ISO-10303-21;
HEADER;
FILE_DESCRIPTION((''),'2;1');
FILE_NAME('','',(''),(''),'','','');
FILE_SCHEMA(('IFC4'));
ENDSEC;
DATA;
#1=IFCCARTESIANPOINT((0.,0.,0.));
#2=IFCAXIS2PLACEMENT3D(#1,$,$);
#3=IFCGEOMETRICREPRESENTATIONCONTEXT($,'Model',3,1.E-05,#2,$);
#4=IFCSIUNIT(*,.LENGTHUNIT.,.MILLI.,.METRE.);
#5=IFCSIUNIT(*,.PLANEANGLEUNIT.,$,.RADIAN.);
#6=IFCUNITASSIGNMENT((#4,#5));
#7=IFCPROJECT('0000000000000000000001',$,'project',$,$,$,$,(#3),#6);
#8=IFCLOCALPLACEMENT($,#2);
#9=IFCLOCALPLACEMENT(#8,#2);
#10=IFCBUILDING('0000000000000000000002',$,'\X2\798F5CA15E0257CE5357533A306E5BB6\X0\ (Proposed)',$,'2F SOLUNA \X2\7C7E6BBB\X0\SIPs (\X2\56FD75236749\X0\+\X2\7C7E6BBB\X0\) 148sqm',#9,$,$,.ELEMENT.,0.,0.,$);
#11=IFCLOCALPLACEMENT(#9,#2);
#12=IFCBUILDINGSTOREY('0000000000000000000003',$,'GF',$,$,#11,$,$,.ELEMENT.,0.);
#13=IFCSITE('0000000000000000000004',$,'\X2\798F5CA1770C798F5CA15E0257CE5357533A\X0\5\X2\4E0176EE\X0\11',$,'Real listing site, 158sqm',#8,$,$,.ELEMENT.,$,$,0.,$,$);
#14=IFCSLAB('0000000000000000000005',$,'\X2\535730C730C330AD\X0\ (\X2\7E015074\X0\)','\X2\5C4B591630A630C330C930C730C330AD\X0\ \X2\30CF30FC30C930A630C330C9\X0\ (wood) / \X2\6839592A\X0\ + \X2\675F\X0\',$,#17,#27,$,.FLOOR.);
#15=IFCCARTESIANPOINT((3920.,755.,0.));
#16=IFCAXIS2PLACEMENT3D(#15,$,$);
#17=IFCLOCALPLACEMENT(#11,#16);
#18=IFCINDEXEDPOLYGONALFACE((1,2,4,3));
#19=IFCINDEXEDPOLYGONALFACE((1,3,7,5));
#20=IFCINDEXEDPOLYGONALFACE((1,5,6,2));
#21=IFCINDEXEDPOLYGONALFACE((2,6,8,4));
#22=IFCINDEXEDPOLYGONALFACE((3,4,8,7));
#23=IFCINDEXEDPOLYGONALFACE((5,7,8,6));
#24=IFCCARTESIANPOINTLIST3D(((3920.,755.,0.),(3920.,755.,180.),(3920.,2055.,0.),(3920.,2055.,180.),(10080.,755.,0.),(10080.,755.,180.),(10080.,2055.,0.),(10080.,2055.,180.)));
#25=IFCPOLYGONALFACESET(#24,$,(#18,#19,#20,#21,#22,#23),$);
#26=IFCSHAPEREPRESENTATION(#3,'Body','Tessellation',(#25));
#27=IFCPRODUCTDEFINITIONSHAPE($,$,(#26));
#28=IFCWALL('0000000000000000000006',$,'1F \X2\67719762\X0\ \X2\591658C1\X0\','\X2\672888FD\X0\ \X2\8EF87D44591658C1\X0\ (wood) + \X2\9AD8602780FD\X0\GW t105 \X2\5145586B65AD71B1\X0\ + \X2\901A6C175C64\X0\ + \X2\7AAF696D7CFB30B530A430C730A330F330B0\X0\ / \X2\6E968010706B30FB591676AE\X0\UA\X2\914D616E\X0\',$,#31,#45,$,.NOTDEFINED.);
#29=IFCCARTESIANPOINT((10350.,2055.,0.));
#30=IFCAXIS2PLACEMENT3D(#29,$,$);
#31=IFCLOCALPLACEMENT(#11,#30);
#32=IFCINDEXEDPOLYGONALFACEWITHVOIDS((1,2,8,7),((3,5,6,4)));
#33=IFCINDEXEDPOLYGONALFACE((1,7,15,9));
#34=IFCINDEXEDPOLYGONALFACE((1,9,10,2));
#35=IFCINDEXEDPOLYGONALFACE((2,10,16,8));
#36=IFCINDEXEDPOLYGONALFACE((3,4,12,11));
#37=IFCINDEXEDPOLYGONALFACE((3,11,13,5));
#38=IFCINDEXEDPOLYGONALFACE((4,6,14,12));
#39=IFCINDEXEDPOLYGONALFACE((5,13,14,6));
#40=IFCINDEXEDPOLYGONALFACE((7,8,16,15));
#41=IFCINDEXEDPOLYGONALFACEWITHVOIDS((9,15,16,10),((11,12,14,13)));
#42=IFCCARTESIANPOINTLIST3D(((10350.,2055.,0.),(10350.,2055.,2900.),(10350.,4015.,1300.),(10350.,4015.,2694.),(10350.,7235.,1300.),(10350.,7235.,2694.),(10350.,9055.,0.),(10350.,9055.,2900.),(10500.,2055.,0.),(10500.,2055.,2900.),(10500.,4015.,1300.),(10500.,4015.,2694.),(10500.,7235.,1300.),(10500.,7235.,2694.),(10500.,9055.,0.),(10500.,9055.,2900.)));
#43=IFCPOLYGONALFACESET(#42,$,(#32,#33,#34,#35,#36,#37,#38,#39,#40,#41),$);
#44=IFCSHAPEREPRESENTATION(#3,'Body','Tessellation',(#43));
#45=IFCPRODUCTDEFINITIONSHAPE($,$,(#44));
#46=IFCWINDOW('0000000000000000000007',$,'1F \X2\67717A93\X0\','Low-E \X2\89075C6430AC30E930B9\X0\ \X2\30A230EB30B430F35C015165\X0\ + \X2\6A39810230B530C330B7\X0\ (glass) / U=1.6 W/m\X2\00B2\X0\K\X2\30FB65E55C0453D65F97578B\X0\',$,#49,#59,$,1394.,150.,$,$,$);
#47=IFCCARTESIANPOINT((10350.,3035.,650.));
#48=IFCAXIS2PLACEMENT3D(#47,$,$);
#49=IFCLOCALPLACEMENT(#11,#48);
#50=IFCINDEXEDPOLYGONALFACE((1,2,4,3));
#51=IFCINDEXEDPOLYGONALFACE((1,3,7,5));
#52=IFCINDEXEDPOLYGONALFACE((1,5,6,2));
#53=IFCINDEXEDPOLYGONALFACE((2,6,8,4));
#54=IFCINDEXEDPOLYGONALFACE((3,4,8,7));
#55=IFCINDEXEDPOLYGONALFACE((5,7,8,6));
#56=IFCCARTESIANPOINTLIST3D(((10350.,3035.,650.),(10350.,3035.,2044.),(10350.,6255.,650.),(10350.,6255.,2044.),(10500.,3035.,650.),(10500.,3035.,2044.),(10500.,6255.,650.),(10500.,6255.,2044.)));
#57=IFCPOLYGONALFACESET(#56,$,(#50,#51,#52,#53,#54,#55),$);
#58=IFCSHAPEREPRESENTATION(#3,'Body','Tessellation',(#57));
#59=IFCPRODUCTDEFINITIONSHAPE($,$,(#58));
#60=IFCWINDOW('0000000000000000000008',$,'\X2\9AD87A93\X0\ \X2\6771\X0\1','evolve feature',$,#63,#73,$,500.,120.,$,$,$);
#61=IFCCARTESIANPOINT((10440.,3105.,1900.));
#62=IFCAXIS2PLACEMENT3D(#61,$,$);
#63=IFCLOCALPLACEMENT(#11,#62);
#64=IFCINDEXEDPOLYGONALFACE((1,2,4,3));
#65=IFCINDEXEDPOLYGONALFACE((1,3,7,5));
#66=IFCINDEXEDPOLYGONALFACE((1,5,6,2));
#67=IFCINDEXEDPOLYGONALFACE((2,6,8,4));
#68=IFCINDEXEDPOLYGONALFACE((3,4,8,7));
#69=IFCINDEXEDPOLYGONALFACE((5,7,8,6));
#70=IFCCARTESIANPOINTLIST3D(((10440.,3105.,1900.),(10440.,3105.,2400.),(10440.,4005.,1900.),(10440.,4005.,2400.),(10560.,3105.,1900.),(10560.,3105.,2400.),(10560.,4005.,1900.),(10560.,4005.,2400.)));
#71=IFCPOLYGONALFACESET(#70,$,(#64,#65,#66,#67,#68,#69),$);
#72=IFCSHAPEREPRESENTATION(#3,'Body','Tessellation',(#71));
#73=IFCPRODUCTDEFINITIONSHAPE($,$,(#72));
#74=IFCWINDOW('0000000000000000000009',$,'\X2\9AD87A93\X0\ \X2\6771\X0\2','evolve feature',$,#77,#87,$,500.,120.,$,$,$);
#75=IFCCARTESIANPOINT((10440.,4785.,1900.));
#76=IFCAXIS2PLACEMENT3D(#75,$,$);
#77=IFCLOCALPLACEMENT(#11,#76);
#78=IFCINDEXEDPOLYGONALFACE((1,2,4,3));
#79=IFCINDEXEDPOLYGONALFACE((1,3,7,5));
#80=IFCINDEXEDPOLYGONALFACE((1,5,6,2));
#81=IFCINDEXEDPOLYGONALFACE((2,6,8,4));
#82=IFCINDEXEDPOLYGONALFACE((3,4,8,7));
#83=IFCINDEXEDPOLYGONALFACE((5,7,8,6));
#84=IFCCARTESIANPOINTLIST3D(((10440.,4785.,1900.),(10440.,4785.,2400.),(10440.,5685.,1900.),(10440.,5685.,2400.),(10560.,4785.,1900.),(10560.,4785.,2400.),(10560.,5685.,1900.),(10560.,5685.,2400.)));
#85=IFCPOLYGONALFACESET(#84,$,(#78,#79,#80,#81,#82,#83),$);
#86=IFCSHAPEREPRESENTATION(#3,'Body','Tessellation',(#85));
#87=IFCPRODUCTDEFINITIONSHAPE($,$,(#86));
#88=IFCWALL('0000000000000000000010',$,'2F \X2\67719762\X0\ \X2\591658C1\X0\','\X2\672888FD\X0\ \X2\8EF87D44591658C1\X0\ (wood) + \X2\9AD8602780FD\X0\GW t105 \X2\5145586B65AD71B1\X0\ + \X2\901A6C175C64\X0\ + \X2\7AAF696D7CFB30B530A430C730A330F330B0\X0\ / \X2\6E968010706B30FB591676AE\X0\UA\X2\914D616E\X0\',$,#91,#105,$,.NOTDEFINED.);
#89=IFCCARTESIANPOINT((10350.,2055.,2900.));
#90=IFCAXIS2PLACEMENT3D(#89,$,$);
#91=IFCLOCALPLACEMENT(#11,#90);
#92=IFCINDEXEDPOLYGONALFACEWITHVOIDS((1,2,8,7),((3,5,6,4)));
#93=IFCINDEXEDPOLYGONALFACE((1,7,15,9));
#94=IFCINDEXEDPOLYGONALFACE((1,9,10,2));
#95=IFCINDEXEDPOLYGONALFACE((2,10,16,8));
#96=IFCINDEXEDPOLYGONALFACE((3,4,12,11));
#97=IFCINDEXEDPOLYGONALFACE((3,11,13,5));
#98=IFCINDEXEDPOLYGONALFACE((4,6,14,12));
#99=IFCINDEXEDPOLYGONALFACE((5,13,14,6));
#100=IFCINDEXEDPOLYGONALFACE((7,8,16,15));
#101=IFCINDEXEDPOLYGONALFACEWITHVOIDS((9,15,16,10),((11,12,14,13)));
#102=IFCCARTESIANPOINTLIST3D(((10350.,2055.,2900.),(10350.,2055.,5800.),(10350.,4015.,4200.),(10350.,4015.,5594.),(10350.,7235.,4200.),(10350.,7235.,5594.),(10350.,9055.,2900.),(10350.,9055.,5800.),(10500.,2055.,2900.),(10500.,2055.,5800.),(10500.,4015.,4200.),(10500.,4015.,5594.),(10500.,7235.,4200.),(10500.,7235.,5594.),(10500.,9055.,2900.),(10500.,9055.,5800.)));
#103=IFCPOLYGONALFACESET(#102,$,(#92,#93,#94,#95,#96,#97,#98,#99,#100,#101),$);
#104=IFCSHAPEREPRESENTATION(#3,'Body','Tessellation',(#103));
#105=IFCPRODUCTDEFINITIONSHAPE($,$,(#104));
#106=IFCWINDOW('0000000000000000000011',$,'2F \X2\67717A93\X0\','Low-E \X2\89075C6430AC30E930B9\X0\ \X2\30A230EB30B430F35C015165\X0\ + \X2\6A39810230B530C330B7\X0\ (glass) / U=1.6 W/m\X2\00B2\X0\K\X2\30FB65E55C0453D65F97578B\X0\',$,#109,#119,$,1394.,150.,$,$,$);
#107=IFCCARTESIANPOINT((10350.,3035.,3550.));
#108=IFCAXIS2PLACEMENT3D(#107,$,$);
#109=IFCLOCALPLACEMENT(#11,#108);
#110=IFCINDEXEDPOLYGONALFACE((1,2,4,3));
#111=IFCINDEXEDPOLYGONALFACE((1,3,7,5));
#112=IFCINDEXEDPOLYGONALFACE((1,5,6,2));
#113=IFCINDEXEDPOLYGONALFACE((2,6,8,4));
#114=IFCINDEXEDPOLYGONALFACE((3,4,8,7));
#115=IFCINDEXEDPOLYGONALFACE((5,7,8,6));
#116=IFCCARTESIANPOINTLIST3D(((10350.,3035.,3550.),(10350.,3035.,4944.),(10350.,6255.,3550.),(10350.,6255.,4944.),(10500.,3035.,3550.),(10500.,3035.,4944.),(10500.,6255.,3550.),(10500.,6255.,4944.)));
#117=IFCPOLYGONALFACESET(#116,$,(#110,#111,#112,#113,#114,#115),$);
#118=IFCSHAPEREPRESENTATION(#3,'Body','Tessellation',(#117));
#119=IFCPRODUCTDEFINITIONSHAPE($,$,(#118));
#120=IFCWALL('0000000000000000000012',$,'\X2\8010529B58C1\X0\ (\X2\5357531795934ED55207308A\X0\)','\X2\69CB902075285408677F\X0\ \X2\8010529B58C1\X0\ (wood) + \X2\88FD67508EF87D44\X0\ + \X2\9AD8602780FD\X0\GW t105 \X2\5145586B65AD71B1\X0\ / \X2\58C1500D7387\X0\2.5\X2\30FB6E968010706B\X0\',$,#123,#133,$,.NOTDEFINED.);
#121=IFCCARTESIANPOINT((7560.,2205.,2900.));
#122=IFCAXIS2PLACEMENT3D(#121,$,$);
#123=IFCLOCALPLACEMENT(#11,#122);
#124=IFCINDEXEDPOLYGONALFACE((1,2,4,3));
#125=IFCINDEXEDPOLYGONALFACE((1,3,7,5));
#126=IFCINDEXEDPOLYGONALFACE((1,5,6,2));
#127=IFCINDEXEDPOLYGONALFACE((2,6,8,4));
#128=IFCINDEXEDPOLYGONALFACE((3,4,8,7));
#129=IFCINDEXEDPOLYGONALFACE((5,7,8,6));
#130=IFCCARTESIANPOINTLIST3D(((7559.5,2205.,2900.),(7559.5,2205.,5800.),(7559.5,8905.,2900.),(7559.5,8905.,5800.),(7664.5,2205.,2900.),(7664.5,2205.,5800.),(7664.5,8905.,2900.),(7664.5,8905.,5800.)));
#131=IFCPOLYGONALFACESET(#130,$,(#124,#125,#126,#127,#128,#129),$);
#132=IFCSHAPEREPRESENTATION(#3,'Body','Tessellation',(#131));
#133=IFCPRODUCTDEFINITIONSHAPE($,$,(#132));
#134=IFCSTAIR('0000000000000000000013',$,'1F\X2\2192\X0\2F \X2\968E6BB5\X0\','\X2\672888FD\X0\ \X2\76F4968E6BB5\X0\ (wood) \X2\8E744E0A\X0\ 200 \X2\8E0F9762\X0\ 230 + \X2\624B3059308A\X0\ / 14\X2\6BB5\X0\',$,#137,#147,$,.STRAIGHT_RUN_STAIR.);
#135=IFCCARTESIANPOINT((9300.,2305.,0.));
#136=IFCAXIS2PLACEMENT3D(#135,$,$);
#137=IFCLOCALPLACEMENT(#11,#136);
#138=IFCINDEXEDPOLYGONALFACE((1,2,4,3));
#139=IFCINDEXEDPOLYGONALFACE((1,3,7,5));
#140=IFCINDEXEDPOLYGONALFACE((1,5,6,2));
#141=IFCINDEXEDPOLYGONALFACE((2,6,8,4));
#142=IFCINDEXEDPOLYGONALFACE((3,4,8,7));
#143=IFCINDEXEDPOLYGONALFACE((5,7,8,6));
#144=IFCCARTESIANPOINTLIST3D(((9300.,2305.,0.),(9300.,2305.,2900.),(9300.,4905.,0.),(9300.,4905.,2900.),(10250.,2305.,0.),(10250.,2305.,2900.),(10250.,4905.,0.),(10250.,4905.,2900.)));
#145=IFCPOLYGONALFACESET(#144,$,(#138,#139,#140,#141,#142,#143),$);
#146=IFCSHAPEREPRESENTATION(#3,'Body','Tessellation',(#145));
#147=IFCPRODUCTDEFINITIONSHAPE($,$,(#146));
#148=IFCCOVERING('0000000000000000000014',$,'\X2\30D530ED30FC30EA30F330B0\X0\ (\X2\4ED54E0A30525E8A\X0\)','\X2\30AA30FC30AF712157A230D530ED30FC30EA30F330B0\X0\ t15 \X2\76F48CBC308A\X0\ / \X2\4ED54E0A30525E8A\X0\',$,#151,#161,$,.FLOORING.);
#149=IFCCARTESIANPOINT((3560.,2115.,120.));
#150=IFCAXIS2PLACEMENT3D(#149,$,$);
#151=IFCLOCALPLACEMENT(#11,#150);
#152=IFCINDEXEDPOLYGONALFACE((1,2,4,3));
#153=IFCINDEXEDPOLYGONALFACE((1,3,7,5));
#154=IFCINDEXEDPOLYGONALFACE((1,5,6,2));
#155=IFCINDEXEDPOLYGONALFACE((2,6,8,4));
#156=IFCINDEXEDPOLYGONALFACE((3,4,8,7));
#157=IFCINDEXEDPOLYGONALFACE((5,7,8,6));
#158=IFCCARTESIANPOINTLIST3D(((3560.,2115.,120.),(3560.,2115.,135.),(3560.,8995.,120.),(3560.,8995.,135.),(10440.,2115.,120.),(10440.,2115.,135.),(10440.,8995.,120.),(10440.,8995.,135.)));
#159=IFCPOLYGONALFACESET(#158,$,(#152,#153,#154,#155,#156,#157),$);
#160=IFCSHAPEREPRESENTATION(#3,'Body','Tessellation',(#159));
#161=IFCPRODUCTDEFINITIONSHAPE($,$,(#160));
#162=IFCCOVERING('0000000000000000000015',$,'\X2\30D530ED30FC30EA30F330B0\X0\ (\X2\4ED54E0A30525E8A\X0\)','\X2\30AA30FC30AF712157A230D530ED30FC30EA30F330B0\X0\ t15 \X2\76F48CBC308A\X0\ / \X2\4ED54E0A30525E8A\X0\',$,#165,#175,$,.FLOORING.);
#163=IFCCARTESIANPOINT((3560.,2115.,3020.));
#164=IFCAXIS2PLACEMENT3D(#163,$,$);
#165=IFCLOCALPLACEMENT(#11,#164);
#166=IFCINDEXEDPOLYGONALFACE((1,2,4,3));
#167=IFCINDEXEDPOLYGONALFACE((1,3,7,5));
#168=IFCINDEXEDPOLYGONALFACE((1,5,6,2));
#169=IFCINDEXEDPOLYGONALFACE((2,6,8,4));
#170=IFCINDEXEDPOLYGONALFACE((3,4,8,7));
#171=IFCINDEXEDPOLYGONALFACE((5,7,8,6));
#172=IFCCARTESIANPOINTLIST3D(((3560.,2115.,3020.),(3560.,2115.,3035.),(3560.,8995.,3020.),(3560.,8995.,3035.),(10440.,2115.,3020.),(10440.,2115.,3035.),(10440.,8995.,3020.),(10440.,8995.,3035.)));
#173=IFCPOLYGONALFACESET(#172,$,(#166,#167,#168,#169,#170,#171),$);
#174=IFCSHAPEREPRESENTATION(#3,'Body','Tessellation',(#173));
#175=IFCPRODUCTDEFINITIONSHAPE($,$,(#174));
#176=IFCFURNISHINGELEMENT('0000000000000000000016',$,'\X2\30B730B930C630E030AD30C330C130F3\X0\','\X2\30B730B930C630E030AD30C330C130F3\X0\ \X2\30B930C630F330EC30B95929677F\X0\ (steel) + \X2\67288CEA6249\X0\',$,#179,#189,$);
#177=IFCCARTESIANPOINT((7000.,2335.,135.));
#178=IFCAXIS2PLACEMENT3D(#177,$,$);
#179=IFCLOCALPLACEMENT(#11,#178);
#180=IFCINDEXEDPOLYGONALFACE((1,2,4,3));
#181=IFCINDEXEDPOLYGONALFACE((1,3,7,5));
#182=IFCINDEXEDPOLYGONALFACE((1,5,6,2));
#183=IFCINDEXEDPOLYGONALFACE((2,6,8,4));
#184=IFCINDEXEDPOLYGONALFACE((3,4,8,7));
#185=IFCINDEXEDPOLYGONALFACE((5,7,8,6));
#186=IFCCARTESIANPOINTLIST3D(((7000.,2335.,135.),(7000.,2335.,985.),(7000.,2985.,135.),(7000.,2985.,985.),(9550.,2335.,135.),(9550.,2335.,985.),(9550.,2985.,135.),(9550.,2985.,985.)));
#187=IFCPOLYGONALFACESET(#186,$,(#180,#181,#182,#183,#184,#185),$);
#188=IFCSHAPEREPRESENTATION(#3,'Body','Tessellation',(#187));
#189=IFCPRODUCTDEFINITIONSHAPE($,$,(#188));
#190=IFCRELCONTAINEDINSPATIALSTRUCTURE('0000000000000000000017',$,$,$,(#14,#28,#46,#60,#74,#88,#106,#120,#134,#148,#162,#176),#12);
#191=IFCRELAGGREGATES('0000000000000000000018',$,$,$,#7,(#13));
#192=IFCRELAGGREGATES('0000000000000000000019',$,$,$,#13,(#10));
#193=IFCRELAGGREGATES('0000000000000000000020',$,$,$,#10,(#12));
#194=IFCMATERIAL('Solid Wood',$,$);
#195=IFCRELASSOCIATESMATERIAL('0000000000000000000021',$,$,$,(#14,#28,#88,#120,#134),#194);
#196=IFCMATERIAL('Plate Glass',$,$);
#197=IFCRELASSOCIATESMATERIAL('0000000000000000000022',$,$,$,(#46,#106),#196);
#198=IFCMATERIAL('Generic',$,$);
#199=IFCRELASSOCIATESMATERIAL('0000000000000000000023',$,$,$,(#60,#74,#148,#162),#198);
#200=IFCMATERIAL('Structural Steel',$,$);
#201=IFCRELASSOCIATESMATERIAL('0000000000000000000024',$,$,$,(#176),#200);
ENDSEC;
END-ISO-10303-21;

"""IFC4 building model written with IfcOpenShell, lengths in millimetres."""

from ifc_helpers import new_model, si_unit, frame, frame_2d, origin, place, context, project, spatial, rectangle, extrude, material, element, fill, save


model = new_model("IFC4")

# Units and contexts
model_context = context("Model", 3, precision=1e-05, world=origin())
ifc_project = project(units=[si_unit("LENGTHUNIT", "METRE", prefix="MILLI"), si_unit("PLANEANGLEUNIT", "RADIAN")], contexts=[model_context])

# Site, building, storey
site_placement = place(None, origin())
site = spatial("IfcSite", under=ifc_project, at=site_placement, Name="福岡県福岡市城南区5丁目11", ObjectType="Real listing site, 158sqm", CompositionType="ELEMENT", RefElevation=0.0)
building_placement = place(site_placement, origin())
building = spatial("IfcBuilding", under=site, at=building_placement, Name="福岡市城南区の家 (Proposed)", ObjectType="2F SOLUNA 籾殻SIPs (国産杉+籾殻) 148sqm", CompositionType="ELEMENT", ElevationOfRefHeight=0.0, ElevationOfTerrain=0.0)
storey_placement = place(building_placement, origin())
storey = spatial("IfcBuildingStorey", under=building, at=storey_placement, Name="GF", CompositionType="ELEMENT", Elevation=0.0)

# Slab
ifc_material_1 = material(Name="Solid Wood")
slab_placement = place(storey_placement, frame((3920.0, 755.0, 0.0)))
element("IfcSlab", 1, at=slab_placement, inside=storey, material=ifc_material_1, Name="南デッキ (縁側)", Description="屋外ウッドデッキ ハードウッド (wood) / 根太 + 束", PredefinedType="FLOOR", context=model_context, shape_type="SweptSolid", body=[
    extrude(rectangle(XDim=6160.0, YDim=1300.0, at=frame_2d((3080.0, 650.0))), frame((3920.0, 755.0, 0.0)), (0.0, 0.0, 1.0), 180.0),
])

# Wall, openings, windows
wall_1_placement = place(storey_placement, frame((10350.0, 2055.0, 0.0)))
wall_1 = element("IfcWall", 2, at=wall_1_placement, inside=storey, material=ifc_material_1, Name="1F 東面 外壁", Description="木製 軸組外壁 (wood) + 高性能GW t105 充填断熱 + 通気層 + 窯業系サイディング / 準耐火・外皮UA配慮", PredefinedType="NOTDEFINED", context=model_context, shape_type="SweptSolid", body=[
    extrude(rectangle(XDim=150.0, YDim=7000.0, at=frame_2d((75.0, 3500.0))), frame((10350.0, 2055.0, 0.0)), (0.0, 0.0, 1.0), 2900.0),
])
opening_1_placement = place(storey_placement, frame((10350.0, 3035.0, 650.0)))
opening_1 = element("IfcOpeningElement", 3, at=opening_1_placement, cuts=wall_1, PredefinedType="NOTDEFINED", context=model_context, shape_type="SweptSolid", body=[
    extrude(rectangle(XDim=150.0, YDim=3220.0, at=frame_2d((75.0, 1610.0))), frame((10350.0, 3035.0, 650.0)), (0.0, 0.0, 1.0), 1394.0),
])
opening_2_placement = place(storey_placement, frame((10440.0, 3105.0, 1900.0)))
opening_2 = element("IfcOpeningElement", 4, at=opening_2_placement, cuts=wall_1, PredefinedType="NOTDEFINED", context=model_context, shape_type="SweptSolid", body=[
    extrude(rectangle(XDim=120.0, YDim=900.0, at=frame_2d((60.0, 450.0))), frame((10440.0, 3105.0, 1900.0)), (0.0, 0.0, 1.0), 500.0),
])
opening_3_placement = place(storey_placement, frame((10440.0, 4785.0, 1900.0)))
opening_3 = element("IfcOpeningElement", 5, at=opening_3_placement, cuts=wall_1, PredefinedType="NOTDEFINED", context=model_context, shape_type="SweptSolid", body=[
    extrude(rectangle(XDim=120.0, YDim=900.0, at=frame_2d((60.0, 450.0))), frame((10440.0, 4785.0, 1900.0)), (0.0, 0.0, 1.0), 500.0),
])
ifc_material_2 = material(Name="Plate Glass")
window_1_placement = place(storey_placement, frame((10350.0, 3035.0, 650.0)))
window_1 = element("IfcWindow", 6, at=window_1_placement, inside=storey, material=ifc_material_2, Name="1F 東窓", Description="Low-E 複層ガラス アルゴン封入 + 樹脂サッシ (glass) / U=1.6 W/m²K・日射取得型", OverallHeight=1394.0, OverallWidth=150.0, context=model_context, shape_type="SweptSolid", body=[
    extrude(rectangle(XDim=150.0, YDim=3220.0, at=frame_2d((75.0, 1610.0))), frame((10350.0, 3035.0, 650.0)), (0.0, 0.0, 1.0), 1394.0),
])
fill(opening_1, window_1)
ifc_material_3 = material(Name="Generic")
window_2_placement = place(storey_placement, frame((10440.0, 3105.0, 1900.0)))
window_2 = element("IfcWindow", 7, at=window_2_placement, inside=storey, material=ifc_material_3, Name="高窓 東1", Description="evolve feature", OverallHeight=500.0, OverallWidth=120.0, context=model_context, shape_type="SweptSolid", body=[
    extrude(rectangle(XDim=120.0, YDim=900.0, at=frame_2d((60.0, 450.0))), frame((10440.0, 3105.0, 1900.0)), (0.0, 0.0, 1.0), 500.0),
])
fill(opening_2, window_2)
window_3_placement = place(storey_placement, frame((10440.0, 4785.0, 1900.0)))
window_3 = element("IfcWindow", 8, at=window_3_placement, inside=storey, material=ifc_material_3, Name="高窓 東2", Description="evolve feature", OverallHeight=500.0, OverallWidth=120.0, context=model_context, shape_type="SweptSolid", body=[
    extrude(rectangle(XDim=120.0, YDim=900.0, at=frame_2d((60.0, 450.0))), frame((10440.0, 4785.0, 1900.0)), (0.0, 0.0, 1.0), 500.0),
])
fill(opening_3, window_3)

# Wall, opening, window
wall_2_placement = place(storey_placement, frame((10350.0, 2055.0, 2900.0)))
wall_2 = element("IfcWall", 9, at=wall_2_placement, inside=storey, material=ifc_material_1, Name="2F 東面 外壁", Description="木製 軸組外壁 (wood) + 高性能GW t105 充填断熱 + 通気層 + 窯業系サイディング / 準耐火・外皮UA配慮", PredefinedType="NOTDEFINED", context=model_context, shape_type="SweptSolid", body=[
    extrude(rectangle(XDim=150.0, YDim=7000.0, at=frame_2d((75.0, 3500.0))), frame((10350.0, 2055.0, 2900.0)), (0.0, 0.0, 1.0), 2900.0),
])
opening_4_placement = place(storey_placement, frame((10350.0, 3035.0, 3550.0)))
opening_4 = element("IfcOpeningElement", 10, at=opening_4_placement, cuts=wall_2, PredefinedType="NOTDEFINED", context=model_context, shape_type="SweptSolid", body=[
    extrude(rectangle(XDim=150.0, YDim=3220.0, at=frame_2d((75.0, 1610.0))), frame((10350.0, 3035.0, 3550.0)), (0.0, 0.0, 1.0), 1394.0),
])
window_4_placement = place(storey_placement, frame((10350.0, 3035.0, 3550.0)))
window_4 = element("IfcWindow", 11, at=window_4_placement, inside=storey, material=ifc_material_2, Name="2F 東窓", Description="Low-E 複層ガラス アルゴン封入 + 樹脂サッシ (glass) / U=1.6 W/m²K・日射取得型", OverallHeight=1394.0, OverallWidth=150.0, context=model_context, shape_type="SweptSolid", body=[
    extrude(rectangle(XDim=150.0, YDim=3220.0, at=frame_2d((75.0, 1610.0))), frame((10350.0, 3035.0, 3550.0)), (0.0, 0.0, 1.0), 1394.0),
])
fill(opening_4, window_4)

# Wall
wall_3_placement = place(storey_placement, frame((7560.0, 2205.0, 2900.0)))
element("IfcWall", 12, at=wall_3_placement, inside=storey, material=ifc_material_1, Name="耐力壁 (南北間仕切り)", Description="構造用合板 耐力壁 (wood) + 製材軸組 + 高性能GW t105 充填断熱 / 壁倍率2.5・準耐火", PredefinedType="NOTDEFINED", context=model_context, shape_type="SweptSolid", body=[
    extrude(rectangle(XDim=105.0, YDim=6700.0, at=frame_2d((52.0, 3350.0))), frame((7560.0, 2205.0, 2900.0)), (0.0, 0.0, 1.0), 2900.0),
])

# Stair
stair_placement = place(storey_placement, frame((9300.0, 2305.0, 0.0)))
element("IfcStair", 13, at=stair_placement, inside=storey, material=ifc_material_1, Name="1F→2F 階段", Description="木製 直階段 (wood) 蹴上 200 踏面 230 + 手すり / 14段", PredefinedType="STRAIGHT_RUN_STAIR", context=model_context, shape_type="SweptSolid", body=[
    extrude(rectangle(XDim=950.0, YDim=2600.0, at=frame_2d((475.0, 1300.0))), frame((9300.0, 2305.0, 0.0)), (0.0, 0.0, 1.0), 2900.0),
])

# Coverings
covering_1_placement = place(storey_placement, frame((3560.0, 2115.0, 120.0)))
element("IfcCovering", 14, at=covering_1_placement, inside=storey, material=ifc_material_3, Name="フローリング (仕上げ床)", Description="オーク無垢フローリング t15 直貼り / 仕上げ床", PredefinedType="FLOORING", context=model_context, shape_type="SweptSolid", body=[
    extrude(rectangle(XDim=6880.0, YDim=6880.0, at=frame_2d((3440.0, 3440.0))), frame((3560.0, 2115.0, 120.0)), (0.0, 0.0, 1.0), 15.0),
])
covering_2_placement = place(storey_placement, frame((3560.0, 2115.0, 3020.0)))
element("IfcCovering", 15, at=covering_2_placement, inside=storey, material=ifc_material_3, Name="フローリング (仕上げ床)", Description="オーク無垢フローリング t15 直貼り / 仕上げ床", PredefinedType="FLOORING", context=model_context, shape_type="SweptSolid", body=[
    extrude(rectangle(XDim=6880.0, YDim=6880.0, at=frame_2d((3440.0, 3440.0))), frame((3560.0, 2115.0, 3020.0)), (0.0, 0.0, 1.0), 15.0),
])

# Furnishing element
ifc_material_4 = material(Name="Structural Steel")
furnishing_1_placement = place(storey_placement, frame((7000.0, 2335.0, 135.0)))
element("IfcFurnishingElement", 16, at=furnishing_1_placement, inside=storey, material=ifc_material_4, Name="システムキッチン", Description="システムキッチン ステンレス天板 (steel) + 木質扉", context=model_context, shape_type="SweptSolid", body=[
    extrude(rectangle(XDim=2550.0, YDim=650.0, at=frame_2d((1275.0, 325.0))), frame((7000.0, 2335.0, 135.0)), (0.0, 0.0, 1.0), 850.0),
])

save(model, "model.ifc")
